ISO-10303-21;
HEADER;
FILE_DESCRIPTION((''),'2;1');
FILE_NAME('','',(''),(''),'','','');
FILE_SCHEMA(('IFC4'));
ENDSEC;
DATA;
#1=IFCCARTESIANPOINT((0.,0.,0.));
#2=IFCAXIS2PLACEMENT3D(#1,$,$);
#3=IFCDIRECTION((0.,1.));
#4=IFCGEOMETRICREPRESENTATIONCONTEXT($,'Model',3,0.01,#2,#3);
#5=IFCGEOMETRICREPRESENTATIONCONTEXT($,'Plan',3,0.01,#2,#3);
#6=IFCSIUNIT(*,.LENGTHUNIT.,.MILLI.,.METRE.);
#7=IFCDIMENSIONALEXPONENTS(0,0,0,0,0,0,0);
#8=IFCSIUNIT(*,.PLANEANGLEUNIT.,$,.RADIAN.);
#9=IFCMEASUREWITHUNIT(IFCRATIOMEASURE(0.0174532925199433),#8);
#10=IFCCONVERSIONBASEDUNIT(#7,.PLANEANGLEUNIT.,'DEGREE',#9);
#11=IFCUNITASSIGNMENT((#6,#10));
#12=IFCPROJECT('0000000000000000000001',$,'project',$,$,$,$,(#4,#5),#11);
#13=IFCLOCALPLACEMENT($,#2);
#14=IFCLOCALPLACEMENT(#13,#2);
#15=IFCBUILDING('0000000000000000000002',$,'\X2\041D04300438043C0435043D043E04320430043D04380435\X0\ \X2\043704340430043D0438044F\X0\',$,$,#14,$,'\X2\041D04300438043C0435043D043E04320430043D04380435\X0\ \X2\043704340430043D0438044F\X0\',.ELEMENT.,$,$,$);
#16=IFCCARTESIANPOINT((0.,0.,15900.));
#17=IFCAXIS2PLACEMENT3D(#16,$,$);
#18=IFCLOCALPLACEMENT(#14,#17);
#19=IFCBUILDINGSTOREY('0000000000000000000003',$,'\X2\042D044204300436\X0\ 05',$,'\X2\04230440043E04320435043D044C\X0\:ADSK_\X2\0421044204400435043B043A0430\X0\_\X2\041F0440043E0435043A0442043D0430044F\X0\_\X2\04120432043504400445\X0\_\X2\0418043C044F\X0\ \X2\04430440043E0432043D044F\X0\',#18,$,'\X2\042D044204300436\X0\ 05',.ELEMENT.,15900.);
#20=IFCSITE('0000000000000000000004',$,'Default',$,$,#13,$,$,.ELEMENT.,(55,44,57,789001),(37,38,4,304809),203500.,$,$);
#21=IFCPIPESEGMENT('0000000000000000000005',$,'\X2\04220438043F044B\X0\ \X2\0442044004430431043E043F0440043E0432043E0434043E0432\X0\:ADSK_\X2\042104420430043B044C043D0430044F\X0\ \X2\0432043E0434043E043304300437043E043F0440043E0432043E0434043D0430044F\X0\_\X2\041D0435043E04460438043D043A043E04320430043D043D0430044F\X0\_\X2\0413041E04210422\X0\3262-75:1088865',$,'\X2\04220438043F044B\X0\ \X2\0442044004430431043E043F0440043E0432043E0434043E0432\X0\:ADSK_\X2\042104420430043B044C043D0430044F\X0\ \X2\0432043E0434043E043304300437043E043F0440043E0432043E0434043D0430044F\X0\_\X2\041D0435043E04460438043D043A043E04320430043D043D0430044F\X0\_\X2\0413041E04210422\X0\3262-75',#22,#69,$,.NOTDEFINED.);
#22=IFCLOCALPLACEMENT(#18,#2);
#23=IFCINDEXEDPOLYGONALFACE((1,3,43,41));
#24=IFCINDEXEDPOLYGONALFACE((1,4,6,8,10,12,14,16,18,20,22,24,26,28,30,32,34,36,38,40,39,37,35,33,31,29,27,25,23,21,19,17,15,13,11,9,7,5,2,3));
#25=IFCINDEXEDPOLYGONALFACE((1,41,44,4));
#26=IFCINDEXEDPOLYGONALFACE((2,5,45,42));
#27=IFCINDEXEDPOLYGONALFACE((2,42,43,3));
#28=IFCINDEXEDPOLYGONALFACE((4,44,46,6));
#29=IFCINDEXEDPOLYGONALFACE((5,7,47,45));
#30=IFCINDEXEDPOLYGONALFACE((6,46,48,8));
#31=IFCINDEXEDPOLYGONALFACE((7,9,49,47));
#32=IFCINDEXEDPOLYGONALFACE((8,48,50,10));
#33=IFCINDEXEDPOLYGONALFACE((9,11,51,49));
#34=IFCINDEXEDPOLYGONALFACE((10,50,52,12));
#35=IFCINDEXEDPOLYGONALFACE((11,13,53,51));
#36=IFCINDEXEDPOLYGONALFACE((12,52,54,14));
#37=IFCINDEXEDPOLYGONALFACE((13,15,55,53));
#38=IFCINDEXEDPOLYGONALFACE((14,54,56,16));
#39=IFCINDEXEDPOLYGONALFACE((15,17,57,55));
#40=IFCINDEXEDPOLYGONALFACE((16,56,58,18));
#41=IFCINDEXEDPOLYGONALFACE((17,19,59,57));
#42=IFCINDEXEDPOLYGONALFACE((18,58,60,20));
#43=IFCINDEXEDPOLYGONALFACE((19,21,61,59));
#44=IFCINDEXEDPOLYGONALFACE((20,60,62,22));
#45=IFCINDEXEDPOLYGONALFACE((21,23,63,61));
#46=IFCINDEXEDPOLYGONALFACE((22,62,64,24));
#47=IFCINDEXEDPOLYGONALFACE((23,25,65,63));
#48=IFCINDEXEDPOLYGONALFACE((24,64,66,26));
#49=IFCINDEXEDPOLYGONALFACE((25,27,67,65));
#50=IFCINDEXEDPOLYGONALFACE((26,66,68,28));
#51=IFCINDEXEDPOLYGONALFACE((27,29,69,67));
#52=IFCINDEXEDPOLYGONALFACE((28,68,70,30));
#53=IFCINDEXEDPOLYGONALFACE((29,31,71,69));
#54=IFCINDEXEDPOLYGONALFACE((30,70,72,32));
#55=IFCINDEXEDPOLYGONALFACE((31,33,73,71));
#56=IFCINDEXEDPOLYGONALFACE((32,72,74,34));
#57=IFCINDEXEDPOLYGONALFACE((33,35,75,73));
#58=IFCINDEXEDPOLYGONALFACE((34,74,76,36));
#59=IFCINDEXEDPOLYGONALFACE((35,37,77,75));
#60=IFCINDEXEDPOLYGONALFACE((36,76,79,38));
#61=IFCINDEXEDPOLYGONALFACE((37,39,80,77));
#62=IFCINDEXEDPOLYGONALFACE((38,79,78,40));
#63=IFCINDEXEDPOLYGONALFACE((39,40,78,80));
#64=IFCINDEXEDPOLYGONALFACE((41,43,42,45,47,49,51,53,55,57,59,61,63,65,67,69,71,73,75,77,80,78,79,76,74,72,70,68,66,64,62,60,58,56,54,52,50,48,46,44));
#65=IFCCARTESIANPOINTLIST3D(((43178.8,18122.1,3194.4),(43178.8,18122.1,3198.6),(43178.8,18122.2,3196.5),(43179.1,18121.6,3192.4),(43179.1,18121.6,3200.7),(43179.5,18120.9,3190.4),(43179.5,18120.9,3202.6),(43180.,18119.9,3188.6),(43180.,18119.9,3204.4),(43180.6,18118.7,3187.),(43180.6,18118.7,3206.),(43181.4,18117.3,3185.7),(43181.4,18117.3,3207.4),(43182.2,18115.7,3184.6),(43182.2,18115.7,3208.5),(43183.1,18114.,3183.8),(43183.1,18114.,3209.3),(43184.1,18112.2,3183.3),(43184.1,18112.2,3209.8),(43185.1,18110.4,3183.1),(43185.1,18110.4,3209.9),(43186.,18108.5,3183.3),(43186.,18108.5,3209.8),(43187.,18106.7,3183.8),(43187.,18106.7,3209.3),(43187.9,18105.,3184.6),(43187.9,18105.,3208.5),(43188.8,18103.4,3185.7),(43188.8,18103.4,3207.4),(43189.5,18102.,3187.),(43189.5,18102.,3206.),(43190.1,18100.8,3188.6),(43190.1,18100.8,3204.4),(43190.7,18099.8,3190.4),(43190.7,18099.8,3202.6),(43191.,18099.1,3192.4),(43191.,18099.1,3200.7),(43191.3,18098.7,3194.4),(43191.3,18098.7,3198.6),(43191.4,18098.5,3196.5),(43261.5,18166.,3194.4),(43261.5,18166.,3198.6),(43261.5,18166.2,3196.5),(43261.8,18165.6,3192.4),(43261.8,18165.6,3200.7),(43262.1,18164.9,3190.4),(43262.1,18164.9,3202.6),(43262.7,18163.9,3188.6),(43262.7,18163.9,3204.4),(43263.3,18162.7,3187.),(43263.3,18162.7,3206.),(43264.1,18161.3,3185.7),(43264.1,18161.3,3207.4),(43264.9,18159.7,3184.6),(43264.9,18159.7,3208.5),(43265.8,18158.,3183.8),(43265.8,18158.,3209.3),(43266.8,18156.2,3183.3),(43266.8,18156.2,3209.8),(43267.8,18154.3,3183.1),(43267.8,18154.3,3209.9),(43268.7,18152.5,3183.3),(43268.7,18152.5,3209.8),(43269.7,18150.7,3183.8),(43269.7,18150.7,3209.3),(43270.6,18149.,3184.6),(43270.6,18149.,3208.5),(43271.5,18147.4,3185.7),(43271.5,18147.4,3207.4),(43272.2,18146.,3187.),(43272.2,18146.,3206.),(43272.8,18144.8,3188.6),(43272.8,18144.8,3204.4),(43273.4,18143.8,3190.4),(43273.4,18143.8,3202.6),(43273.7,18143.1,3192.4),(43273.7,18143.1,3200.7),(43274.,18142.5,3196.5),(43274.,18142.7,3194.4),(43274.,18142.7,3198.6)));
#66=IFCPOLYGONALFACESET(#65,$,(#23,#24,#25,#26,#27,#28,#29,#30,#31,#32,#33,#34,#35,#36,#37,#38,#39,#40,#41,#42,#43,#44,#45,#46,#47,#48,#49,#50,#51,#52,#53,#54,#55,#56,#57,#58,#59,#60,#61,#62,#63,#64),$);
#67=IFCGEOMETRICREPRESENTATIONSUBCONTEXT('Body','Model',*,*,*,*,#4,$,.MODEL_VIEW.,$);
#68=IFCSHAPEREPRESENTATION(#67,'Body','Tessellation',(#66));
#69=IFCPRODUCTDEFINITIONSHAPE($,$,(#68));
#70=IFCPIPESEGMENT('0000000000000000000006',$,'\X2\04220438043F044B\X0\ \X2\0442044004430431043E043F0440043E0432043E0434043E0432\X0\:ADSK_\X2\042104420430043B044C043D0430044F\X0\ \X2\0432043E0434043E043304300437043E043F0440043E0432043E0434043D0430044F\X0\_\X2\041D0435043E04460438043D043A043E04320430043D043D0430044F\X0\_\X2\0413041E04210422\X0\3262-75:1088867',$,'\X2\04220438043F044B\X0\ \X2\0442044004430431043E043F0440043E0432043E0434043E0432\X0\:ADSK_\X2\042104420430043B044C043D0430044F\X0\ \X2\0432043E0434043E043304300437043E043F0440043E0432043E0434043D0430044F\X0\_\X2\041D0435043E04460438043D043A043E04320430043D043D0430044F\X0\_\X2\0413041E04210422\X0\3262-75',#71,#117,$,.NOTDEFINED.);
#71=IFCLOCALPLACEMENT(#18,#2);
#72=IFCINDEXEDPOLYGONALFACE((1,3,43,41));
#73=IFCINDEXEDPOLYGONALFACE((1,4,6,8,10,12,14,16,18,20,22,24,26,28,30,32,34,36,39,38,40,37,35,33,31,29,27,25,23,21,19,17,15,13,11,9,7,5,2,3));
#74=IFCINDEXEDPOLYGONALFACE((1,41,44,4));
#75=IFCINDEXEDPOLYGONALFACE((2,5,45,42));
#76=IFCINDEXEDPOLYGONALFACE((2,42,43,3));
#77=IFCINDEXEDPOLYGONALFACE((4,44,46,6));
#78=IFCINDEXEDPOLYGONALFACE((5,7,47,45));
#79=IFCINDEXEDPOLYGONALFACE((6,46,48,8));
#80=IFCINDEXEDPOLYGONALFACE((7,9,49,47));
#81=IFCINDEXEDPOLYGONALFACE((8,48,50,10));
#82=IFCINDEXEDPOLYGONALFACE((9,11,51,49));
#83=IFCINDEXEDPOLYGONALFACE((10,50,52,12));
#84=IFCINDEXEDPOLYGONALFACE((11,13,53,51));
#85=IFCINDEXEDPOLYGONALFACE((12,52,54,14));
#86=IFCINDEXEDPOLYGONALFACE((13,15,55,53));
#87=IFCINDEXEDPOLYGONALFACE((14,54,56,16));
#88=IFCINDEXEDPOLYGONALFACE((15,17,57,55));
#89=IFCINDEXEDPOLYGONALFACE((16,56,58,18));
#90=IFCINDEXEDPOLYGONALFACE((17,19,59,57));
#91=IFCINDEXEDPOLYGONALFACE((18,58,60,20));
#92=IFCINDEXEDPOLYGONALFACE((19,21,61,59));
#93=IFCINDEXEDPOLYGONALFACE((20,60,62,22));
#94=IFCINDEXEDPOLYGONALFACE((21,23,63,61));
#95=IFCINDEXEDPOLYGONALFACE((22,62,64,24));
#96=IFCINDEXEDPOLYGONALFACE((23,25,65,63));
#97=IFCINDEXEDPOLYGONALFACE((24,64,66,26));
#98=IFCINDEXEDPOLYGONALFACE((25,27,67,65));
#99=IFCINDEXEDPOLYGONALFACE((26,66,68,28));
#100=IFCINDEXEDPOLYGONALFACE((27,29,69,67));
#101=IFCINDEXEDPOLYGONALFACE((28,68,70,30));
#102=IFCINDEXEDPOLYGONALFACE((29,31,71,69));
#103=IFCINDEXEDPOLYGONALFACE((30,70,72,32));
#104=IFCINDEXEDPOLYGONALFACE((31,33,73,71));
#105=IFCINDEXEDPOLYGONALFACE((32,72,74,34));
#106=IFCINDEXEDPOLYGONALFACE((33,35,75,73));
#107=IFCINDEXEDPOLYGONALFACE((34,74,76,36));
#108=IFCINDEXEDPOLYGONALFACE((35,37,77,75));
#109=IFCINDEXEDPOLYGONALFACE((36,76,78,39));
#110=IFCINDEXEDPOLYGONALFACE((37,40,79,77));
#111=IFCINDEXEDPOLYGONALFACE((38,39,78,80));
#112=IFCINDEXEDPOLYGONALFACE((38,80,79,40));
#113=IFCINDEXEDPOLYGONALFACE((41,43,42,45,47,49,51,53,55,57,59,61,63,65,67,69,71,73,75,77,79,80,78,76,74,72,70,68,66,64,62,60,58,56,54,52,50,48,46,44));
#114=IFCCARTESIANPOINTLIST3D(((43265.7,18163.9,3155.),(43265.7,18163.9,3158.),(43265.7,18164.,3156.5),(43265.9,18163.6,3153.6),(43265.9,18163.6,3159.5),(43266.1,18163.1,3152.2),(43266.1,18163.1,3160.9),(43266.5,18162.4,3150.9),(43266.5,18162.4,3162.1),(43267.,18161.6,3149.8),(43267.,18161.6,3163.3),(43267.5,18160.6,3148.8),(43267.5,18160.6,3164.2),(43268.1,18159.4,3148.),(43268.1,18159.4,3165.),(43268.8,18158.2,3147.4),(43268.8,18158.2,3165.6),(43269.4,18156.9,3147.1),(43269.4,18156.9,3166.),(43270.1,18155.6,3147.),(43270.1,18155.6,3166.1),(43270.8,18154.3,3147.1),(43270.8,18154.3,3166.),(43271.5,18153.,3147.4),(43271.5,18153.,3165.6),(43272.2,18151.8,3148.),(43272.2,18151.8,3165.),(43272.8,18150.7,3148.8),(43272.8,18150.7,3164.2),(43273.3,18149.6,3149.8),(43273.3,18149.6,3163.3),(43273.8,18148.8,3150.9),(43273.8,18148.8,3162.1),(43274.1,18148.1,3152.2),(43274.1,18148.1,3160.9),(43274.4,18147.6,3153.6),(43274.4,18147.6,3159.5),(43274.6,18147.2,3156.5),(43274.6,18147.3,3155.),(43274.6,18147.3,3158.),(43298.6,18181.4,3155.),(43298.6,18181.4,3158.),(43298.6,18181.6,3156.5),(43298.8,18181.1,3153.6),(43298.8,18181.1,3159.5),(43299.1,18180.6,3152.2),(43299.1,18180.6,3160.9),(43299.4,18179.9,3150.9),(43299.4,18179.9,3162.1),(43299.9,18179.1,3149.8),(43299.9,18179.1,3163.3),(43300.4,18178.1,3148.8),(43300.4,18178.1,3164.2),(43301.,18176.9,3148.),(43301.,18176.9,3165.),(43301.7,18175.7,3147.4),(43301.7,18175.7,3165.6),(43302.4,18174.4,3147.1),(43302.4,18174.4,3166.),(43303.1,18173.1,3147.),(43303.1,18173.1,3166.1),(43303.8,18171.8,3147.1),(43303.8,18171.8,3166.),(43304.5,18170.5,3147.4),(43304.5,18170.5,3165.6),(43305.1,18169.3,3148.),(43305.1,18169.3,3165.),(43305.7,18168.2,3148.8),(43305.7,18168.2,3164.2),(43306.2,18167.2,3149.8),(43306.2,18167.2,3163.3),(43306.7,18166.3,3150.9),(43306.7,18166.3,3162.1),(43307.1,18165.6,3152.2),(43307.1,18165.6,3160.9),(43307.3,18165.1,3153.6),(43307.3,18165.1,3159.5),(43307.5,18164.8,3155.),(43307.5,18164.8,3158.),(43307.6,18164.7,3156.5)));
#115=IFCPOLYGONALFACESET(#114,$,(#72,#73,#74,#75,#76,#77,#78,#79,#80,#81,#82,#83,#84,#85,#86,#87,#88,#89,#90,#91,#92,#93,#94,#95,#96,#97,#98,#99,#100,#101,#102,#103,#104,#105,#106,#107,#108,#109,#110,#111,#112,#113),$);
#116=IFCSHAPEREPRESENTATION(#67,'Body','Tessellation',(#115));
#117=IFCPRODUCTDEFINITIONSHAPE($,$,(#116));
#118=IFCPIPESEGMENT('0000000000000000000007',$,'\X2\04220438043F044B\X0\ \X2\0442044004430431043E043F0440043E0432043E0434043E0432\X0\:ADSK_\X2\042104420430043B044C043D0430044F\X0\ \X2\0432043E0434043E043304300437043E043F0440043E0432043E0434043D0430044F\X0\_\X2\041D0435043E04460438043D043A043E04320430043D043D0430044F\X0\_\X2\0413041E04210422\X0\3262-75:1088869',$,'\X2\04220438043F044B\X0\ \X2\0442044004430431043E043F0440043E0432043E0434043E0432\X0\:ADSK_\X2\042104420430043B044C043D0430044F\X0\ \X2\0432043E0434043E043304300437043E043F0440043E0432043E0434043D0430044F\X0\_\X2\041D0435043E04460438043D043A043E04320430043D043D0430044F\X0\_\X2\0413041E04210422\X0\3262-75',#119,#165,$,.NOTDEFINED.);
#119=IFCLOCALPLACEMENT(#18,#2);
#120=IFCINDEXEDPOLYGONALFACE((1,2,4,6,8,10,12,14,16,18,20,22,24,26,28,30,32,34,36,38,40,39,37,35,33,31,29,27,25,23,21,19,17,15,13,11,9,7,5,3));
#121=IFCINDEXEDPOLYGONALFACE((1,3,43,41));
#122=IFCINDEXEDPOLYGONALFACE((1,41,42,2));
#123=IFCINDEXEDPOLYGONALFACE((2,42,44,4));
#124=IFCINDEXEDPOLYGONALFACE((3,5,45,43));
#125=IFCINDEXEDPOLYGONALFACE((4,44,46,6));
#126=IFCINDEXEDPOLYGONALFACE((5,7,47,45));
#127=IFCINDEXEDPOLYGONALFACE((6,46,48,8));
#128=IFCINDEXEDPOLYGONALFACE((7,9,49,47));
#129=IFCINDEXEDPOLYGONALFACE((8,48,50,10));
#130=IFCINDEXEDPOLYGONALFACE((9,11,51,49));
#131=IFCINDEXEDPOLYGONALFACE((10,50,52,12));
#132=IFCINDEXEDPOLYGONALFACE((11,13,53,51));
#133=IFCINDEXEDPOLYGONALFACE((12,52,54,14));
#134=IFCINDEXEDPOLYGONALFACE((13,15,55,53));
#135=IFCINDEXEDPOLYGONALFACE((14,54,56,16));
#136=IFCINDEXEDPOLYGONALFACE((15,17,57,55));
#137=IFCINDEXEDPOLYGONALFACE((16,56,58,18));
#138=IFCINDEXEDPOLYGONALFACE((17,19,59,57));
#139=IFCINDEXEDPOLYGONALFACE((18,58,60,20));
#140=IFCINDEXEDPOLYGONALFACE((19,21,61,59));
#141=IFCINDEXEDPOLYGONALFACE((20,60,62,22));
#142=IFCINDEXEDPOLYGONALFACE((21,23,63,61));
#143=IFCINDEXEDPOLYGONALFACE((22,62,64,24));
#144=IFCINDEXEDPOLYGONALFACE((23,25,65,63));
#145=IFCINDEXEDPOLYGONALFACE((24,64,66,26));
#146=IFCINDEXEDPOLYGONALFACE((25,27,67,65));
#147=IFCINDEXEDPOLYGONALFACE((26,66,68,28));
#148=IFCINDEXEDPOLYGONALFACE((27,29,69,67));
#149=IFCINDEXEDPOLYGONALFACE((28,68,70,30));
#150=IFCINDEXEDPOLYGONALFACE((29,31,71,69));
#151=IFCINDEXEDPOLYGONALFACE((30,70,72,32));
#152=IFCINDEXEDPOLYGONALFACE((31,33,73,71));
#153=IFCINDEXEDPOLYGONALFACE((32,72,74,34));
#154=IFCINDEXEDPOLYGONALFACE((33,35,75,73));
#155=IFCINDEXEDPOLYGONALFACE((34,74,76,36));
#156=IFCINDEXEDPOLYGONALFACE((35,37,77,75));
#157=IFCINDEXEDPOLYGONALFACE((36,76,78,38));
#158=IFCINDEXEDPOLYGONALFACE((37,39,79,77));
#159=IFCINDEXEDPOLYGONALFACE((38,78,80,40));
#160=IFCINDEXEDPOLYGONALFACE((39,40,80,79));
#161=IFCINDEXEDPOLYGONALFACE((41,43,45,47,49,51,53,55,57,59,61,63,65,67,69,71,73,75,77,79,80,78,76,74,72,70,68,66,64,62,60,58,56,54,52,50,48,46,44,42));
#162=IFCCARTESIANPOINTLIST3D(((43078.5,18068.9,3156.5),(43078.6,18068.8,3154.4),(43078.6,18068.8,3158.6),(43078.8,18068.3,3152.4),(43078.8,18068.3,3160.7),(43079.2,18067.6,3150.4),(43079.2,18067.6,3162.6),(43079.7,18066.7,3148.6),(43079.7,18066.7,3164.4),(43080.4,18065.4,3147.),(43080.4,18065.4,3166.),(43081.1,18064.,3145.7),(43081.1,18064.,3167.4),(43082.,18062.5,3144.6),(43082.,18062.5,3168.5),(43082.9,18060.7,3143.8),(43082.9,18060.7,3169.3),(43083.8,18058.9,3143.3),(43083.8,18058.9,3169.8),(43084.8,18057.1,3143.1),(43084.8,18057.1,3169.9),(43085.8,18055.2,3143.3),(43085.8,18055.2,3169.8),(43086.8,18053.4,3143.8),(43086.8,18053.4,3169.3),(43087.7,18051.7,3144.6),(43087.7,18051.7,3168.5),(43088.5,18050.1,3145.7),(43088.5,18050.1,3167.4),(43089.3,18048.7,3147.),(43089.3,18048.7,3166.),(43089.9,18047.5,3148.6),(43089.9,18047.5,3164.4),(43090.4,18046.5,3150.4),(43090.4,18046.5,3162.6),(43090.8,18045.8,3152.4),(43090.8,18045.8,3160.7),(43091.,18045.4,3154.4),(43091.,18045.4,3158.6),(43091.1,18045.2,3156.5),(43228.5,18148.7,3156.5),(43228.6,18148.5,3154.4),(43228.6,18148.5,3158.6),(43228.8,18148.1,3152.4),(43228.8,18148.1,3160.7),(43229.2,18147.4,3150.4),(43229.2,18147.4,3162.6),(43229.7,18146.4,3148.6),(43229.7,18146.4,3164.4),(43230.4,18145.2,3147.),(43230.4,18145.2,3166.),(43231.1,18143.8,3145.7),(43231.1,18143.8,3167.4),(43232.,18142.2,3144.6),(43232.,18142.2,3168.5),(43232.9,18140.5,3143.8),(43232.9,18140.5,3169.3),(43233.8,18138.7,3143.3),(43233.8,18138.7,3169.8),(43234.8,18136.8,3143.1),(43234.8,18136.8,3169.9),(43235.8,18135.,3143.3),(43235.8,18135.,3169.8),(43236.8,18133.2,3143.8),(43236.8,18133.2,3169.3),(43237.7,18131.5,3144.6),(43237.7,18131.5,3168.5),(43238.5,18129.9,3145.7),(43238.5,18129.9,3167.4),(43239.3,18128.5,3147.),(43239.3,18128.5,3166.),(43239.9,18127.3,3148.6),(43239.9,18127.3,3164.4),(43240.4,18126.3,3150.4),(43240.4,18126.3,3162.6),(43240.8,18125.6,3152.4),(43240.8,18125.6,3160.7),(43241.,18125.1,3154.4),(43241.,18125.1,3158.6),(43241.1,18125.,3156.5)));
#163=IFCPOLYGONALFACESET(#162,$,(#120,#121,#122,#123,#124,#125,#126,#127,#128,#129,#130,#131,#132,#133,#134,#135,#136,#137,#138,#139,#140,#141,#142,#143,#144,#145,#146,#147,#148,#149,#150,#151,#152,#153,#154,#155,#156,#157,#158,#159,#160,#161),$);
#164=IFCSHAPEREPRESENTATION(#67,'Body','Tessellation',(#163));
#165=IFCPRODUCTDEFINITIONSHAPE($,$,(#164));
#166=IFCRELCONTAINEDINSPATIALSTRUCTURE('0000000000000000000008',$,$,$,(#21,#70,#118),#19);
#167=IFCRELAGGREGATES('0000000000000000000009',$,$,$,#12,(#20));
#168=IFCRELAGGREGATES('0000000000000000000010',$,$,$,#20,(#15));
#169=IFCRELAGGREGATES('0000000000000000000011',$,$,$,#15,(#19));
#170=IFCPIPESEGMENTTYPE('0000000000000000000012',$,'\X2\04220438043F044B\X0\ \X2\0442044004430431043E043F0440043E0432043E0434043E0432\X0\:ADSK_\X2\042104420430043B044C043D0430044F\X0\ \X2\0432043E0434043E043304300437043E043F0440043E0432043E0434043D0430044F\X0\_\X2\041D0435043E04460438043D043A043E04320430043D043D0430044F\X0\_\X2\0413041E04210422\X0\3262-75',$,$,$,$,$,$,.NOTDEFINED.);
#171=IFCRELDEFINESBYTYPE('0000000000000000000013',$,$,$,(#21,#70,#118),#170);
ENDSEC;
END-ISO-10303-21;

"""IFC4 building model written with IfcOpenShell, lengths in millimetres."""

from ifc_helpers import new_model, entity, si_unit, converted_unit, direction, frame, origin, place, context, subcontext, project, spatial, indexed_curve, outline, extrude, type_object, element, save


model = new_model("IFC4")

# Units and contexts
model_context = context("Model", 3, precision=0.01, world=origin(), true_north=direction((0.0, 1.0)))
plan_context = context("Plan", 3, precision=0.01, world=origin(), true_north=direction((0.0, 1.0)))
body_context = subcontext(model_context, "Body", "Model", "MODEL_VIEW")
ifc_project = project(units=[si_unit("LENGTHUNIT", "METRE", prefix="MILLI"), converted_unit("PLANEANGLEUNIT", "DEGREE", entity("IfcRatioMeasure", 0.0174532925199433), si_unit("PLANEANGLEUNIT", "RADIAN"), dimensions=[0, 0, 0, 0, 0, 0, 0])], contexts=[model_context, plan_context])

# Site, building, storey
site_placement = place(None, origin())
site = spatial("IfcSite", under=ifc_project, at=site_placement, Name="Default", CompositionType="ELEMENT", RefLatitude=(55, 44, 57, 789001), RefLongitude=(37, 38, 4, 304809), RefElevation=203500.0)
building_placement = place(site_placement, origin())
building = spatial("IfcBuilding", under=site, at=building_placement, Name="Наименование здания", LongName="Наименование здания", CompositionType="ELEMENT")
storey_placement = place(building_placement, frame((0.0, 0.0, 15900.0)))
storey = spatial("IfcBuildingStorey", under=building, at=storey_placement, Name="Этаж 05", ObjectType="Уровень:ADSK_Стрелка_Проектная_Вверх_Имя уровня", LongName="Этаж 05", CompositionType="ELEMENT", Elevation=15900.0)

# Pipe segments
placement = place(storey_placement, origin())
pipe_segment_type_1 = type_object("IfcPipeSegmentType", Name="Типы трубопроводов:ADSK_Стальная водогазопроводная_Неоцинкованная_ГОСТ3262-75", PredefinedType="NOTDEFINED")
element("IfcPipeSegment", 1, at=placement, inside=storey, type_object=pipe_segment_type_1, Name="Типы трубопроводов:ADSK_Стальная водогазопроводная_Неоцинкованная_ГОСТ3262-75:1088865", ObjectType="Типы трубопроводов:ADSK_Стальная водогазопроводная_Неоцинкованная_ГОСТ3262-75", PredefinedType="NOTDEFINED", context=body_context, shape_type="SweptSolid", body=[
    extrude(outline(indexed_curve([(13.4, 0.0), (13.2, 2.1), (12.7, 4.1), (11.9, 6.1), (10.8, 7.9), (9.5, 9.5), (7.9, 10.8), (6.1, 11.9), (4.1, 12.7), (2.1, 13.2), (0.0, 13.4), (-2.1, 13.2), (-4.1, 12.7), (-6.1, 11.9), (-7.9, 10.8), (-9.5, 9.5), (-10.8, 7.9), (-11.9, 6.1), (-12.7, 4.1), (-13.2, 2.1), (-13.4, 0.0), (-13.2, -2.1), (-12.7, -4.1), (-11.9, -6.1), (-10.8, -7.9), (-9.5, -9.5), (-7.9, -10.8), (-6.1, -11.9), (-4.1, -12.7), (-2.1, -13.2), (0.0, -13.4), (2.1, -13.2), (4.1, -12.7), (6.1, -11.9), (7.9, -10.8), (9.5, -9.5), (10.8, -7.9), (11.9, -6.1), (12.7, -4.1), (13.2, -2.1), (13.4, 0.0)], self_intersect=False)), frame((43185.1, 18110.4, 3196.5), z_axis=(0.882948, 0.469472, 0.0), x_axis=(0.469472, -0.882948, 0.0)), (0.0, 0.0, 1.0), 93.7),
])
element("IfcPipeSegment", 2, at=placement, inside=storey, type_object=pipe_segment_type_1, Name="Типы трубопроводов:ADSK_Стальная водогазопроводная_Неоцинкованная_ГОСТ3262-75:1088867", ObjectType="Типы трубопроводов:ADSK_Стальная водогазопроводная_Неоцинкованная_ГОСТ3262-75", PredefinedType="NOTDEFINED", context=body_context, shape_type="SweptSolid", body=[
    extrude(outline(indexed_curve([(9.6, 0.0), (9.4, 1.5), (9.1, 3.0), (8.5, 4.3), (7.7, 5.6), (6.8, 6.8), (5.6, 7.7), (4.3, 8.5), (3.0, 9.1), (1.5, 9.4), (0.0, 9.6), (-1.5, 9.4), (-3.0, 9.1), (-4.3, 8.5), (-5.6, 7.7), (-6.8, 6.8), (-7.7, 5.6), (-8.5, 4.3), (-9.1, 3.0), (-9.4, 1.5), (-9.6, 0.0), (-9.4, -1.5), (-9.1, -3.0), (-8.5, -4.3), (-7.7, -5.6), (-6.8, -6.8), (-5.6, -7.7), (-4.3, -8.5), (-3.0, -9.1), (-1.5, -9.4), (0.0, -9.6), (1.5, -9.4), (3.0, -9.1), (4.3, -8.5), (5.6, -7.7), (6.8, -6.8), (7.7, -5.6), (8.5, -4.3), (9.1, -3.0), (9.4, -1.5), (9.6, 0.0)], self_intersect=False)), frame((43270.1, 18155.6, 3156.5), z_axis=(0.882948, 0.469472, 0.0), x_axis=(-0.469472, 0.882948, 0.0)), (0.0, 0.0, 1.0), 37.3),
])
element("IfcPipeSegment", 3, at=placement, inside=storey, type_object=pipe_segment_type_1, Name="Типы трубопроводов:ADSK_Стальная водогазопроводная_Неоцинкованная_ГОСТ3262-75:1088869", ObjectType="Типы трубопроводов:ADSK_Стальная водогазопроводная_Неоцинкованная_ГОСТ3262-75", PredefinedType="NOTDEFINED", context=body_context, shape_type="SweptSolid", body=[
    extrude(outline(indexed_curve([(13.4, 0.0), (13.2, 2.1), (12.7, 4.1), (11.9, 6.1), (10.8, 7.9), (9.5, 9.5), (7.9, 10.8), (6.1, 11.9), (4.1, 12.7), (2.1, 13.2), (0.0, 13.4), (-2.1, 13.2), (-4.1, 12.7), (-6.1, 11.9), (-7.9, 10.8), (-9.5, 9.5), (-10.8, 7.9), (-11.9, 6.1), (-12.7, 4.1), (-13.2, 2.1), (-13.4, 0.0), (-13.2, -2.1), (-12.7, -4.1), (-11.9, -6.1), (-10.8, -7.9), (-9.5, -9.5), (-7.9, -10.8), (-6.1, -11.9), (-4.1, -12.7), (-2.1, -13.2), (0.0, -13.4), (2.1, -13.2), (4.1, -12.7), (6.1, -11.9), (7.9, -10.8), (9.5, -9.5), (10.8, -7.9), (11.9, -6.1), (12.7, -4.1), (13.2, -2.1), (13.4, 0.0)], self_intersect=False)), frame((43084.8, 18057.1, 3156.5), z_axis=(0.882948, 0.469472, 0.0), x_axis=(0.469472, -0.882948, 0.0)), (0.0, 0.0, 1.0), 169.9),
])

save(model, "model.ifc")
